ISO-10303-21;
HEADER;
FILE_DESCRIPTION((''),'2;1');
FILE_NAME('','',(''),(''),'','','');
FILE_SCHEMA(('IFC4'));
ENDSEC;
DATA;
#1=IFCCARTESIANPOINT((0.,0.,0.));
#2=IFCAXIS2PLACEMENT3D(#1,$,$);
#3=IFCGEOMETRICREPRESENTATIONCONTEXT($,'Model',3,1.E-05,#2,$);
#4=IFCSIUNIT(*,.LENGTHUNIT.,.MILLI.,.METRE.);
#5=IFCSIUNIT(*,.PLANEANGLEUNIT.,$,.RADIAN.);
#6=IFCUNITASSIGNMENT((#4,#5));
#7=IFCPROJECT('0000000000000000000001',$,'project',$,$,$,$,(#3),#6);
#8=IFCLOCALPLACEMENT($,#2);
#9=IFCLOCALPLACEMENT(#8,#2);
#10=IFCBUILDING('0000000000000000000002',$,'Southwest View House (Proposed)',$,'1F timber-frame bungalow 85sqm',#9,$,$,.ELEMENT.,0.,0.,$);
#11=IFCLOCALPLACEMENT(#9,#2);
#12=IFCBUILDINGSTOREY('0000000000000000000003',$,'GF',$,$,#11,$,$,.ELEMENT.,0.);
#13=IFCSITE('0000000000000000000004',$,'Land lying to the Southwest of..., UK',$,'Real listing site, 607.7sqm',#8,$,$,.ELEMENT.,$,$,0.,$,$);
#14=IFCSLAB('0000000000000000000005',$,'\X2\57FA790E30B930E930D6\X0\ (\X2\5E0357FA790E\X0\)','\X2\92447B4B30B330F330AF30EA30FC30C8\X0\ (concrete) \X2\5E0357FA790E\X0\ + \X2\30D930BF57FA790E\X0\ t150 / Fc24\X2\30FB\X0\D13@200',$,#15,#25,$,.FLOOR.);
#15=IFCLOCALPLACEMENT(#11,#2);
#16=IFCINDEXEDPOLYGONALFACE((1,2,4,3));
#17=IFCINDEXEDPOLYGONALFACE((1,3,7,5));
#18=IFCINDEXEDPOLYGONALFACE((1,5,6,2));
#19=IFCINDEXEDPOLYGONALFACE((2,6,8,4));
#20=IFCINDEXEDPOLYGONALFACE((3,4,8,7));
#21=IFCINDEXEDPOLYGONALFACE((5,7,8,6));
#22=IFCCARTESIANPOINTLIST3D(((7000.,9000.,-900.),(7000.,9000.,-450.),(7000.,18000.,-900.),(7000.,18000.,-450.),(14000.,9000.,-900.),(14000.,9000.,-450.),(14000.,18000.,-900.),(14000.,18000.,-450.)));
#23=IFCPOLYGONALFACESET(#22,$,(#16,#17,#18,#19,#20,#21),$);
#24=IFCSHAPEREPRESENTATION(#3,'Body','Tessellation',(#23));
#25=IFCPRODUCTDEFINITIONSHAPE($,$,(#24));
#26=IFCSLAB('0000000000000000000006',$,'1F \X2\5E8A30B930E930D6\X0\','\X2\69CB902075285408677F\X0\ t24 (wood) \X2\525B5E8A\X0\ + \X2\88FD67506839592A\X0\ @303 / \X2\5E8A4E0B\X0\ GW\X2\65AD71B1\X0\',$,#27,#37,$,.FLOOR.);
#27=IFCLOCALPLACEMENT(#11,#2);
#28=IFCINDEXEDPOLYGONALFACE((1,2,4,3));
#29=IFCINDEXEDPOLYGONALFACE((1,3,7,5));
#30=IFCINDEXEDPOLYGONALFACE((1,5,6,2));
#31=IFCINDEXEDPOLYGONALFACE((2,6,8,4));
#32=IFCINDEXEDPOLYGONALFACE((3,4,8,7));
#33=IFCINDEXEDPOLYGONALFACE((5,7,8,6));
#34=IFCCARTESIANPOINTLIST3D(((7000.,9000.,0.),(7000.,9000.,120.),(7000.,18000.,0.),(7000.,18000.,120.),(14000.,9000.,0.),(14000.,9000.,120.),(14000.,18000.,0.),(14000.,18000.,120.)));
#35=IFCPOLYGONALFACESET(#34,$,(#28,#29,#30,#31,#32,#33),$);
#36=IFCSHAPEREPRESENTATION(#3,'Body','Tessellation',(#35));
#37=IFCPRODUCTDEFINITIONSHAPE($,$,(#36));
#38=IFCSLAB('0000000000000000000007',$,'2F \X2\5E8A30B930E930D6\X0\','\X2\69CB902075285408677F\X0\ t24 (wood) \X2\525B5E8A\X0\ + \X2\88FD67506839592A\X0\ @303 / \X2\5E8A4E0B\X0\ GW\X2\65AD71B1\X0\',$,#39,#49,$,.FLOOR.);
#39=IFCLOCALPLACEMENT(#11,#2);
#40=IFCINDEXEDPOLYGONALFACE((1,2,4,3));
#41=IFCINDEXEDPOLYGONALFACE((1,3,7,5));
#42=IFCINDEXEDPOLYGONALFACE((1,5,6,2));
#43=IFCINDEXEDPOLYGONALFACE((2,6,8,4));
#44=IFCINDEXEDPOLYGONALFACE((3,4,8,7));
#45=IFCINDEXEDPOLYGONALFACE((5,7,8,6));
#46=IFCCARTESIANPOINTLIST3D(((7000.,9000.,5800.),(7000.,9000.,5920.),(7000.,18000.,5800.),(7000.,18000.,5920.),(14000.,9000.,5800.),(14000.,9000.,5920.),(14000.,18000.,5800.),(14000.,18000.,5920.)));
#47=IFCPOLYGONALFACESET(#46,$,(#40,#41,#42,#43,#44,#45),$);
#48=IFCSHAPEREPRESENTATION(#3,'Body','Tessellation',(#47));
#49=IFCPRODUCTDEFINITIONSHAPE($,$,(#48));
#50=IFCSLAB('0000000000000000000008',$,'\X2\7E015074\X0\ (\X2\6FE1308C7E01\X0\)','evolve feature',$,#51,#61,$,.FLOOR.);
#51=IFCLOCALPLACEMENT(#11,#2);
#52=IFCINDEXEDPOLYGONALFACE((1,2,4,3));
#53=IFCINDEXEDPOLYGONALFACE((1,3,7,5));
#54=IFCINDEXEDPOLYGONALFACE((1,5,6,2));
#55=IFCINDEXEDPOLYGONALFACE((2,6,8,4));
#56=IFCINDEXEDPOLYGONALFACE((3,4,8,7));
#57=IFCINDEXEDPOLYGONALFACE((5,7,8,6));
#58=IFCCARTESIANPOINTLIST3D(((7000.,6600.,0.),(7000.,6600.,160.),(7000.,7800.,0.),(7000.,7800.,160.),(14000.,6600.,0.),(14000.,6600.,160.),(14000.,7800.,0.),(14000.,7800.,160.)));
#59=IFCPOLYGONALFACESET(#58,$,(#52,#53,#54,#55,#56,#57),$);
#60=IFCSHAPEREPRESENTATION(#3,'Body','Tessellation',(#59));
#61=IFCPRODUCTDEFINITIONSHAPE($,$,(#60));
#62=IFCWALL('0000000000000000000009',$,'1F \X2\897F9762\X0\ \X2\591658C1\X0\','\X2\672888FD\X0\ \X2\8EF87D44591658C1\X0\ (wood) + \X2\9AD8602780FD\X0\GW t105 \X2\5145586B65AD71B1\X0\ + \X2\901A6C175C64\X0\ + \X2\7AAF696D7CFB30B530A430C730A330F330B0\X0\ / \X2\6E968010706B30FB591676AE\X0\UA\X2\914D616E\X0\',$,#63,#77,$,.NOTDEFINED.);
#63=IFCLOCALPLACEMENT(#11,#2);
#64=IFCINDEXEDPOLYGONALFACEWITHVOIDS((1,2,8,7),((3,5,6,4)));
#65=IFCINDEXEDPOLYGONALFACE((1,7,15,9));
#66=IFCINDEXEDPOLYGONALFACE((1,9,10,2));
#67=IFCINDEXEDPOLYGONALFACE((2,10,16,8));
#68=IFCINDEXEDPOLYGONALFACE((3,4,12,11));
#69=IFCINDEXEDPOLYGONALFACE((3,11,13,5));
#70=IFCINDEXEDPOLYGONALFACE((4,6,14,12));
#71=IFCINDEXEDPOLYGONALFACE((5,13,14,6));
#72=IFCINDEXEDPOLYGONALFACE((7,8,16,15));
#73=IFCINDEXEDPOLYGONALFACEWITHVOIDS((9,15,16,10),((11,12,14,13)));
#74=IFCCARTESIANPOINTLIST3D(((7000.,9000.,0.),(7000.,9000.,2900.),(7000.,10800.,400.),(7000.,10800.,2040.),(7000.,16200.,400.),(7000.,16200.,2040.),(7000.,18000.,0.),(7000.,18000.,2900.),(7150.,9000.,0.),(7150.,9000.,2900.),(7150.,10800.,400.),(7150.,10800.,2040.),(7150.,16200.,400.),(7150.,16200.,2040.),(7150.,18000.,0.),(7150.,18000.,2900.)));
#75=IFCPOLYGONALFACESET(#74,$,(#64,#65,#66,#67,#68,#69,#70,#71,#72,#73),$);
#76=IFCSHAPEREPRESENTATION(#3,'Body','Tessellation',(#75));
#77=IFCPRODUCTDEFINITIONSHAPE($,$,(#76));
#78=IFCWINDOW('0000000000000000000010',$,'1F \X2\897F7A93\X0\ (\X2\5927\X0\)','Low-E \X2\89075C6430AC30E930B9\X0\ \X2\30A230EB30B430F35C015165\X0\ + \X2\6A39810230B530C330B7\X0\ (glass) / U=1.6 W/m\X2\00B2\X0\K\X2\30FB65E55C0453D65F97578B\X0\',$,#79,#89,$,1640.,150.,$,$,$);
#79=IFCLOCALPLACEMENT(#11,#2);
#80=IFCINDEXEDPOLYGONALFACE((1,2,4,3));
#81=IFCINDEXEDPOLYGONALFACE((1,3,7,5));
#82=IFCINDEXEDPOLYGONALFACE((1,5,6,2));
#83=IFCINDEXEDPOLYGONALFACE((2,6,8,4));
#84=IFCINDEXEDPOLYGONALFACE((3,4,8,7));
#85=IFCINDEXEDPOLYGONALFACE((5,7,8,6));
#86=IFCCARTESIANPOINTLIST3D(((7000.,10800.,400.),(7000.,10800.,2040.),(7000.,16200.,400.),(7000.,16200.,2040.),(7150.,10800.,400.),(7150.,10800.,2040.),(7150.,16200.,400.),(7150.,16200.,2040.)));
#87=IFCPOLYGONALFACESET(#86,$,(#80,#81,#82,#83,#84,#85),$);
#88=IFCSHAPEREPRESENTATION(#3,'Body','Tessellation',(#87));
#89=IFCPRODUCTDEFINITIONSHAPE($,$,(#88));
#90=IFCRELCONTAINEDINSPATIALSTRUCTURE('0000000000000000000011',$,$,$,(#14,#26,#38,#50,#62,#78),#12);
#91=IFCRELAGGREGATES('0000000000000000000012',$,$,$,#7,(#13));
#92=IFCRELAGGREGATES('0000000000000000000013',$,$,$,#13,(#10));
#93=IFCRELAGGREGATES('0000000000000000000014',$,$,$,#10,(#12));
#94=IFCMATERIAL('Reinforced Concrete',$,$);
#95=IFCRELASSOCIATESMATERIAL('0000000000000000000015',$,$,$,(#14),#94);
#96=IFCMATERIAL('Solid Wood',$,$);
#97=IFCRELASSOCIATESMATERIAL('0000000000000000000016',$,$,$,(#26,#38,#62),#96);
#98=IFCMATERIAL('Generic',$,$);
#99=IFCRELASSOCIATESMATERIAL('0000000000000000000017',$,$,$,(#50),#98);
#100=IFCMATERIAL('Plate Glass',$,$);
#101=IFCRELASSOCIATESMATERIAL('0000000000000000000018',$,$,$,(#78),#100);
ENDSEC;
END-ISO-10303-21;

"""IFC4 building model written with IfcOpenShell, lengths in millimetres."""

from ifc_helpers import new_model, si_unit, frame, frame_2d, origin, place, context, project, spatial, rectangle, extrude, material, element, fill, save


model = new_model("IFC4")

# Units and contexts
model_context = context("Model", 3, precision=1e-05, world=origin())
ifc_project = project(units=[si_unit("LENGTHUNIT", "METRE", prefix="MILLI"), si_unit("PLANEANGLEUNIT", "RADIAN")], contexts=[model_context])

# Site, building, storey
site_placement = place(None, origin())
site = spatial("IfcSite", under=ifc_project, at=site_placement, Name="Land lying to the Southwest of..., UK", ObjectType="Real listing site, 607.7sqm", CompositionType="ELEMENT", RefElevation=0.0)
building_placement = place(site_placement, origin())
building = spatial("IfcBuilding", under=site, at=building_placement, Name="Southwest View House (Proposed)", ObjectType="1F timber-frame bungalow 85sqm", CompositionType="ELEMENT", ElevationOfRefHeight=0.0, ElevationOfTerrain=0.0)
storey_placement = place(building_placement, origin())
storey = spatial("IfcBuildingStorey", under=building, at=storey_placement, Name="GF", CompositionType="ELEMENT", Elevation=0.0)

# Slabs
ifc_material_1 = material(Name="Reinforced Concrete")
slab_1_placement = place(storey_placement, frame((3500.0, 4500.0, -450.0)))
element("IfcSlab", 1, at=slab_1_placement, inside=storey, material=ifc_material_1, Name="基礎スラブ (布基礎)", Description="鉄筋コンクリート (concrete) 布基礎 + ベタ基礎 t150 / Fc24・D13@200", PredefinedType="FLOOR", context=model_context, shape_type="SweptSolid", body=[
    extrude(rectangle(XDim=7000.0, YDim=9000.0, at=frame_2d((3500.0, 4500.0))), frame((3500.0, 4500.0, -450.0)), (0.0, 0.0, 1.0), 450.0),
])
ifc_material_2 = material(Name="Solid Wood")
slab_2_placement = place(storey_placement, frame((3500.0, 4500.0, 0.0)))
element("IfcSlab", 2, at=slab_2_placement, inside=storey, material=ifc_material_2, Name="1F 床スラブ", Description="構造用合板 t24 (wood) 剛床 + 製材根太 @303 / 床下 GW断熱", PredefinedType="FLOOR", context=model_context, shape_type="SweptSolid", body=[
    extrude(rectangle(XDim=7000.0, YDim=9000.0, at=frame_2d((3500.0, 4500.0))), frame((3500.0, 4500.0, 0.0)), (0.0, 0.0, 1.0), 120.0),
])
slab_3_placement = place(storey_placement, frame((3500.0, 4500.0, 2900.0)))
element("IfcSlab", 3, at=slab_3_placement, inside=storey, material=ifc_material_2, Name="2F 床スラブ", Description="構造用合板 t24 (wood) 剛床 + 製材根太 @303 / 床下 GW断熱", PredefinedType="FLOOR", context=model_context, shape_type="SweptSolid", body=[
    extrude(rectangle(XDim=7000.0, YDim=9000.0, at=frame_2d((3500.0, 4500.0))), frame((3500.0, 4500.0, 2900.0)), (0.0, 0.0, 1.0), 120.0),
])
ifc_material_3 = material(Name="Generic")
slab_4_placement = place(storey_placement, frame((3500.0, 3300.0, 0.0)))
element("IfcSlab", 4, at=slab_4_placement, inside=storey, material=ifc_material_3, Name="縁側 (濡れ縁)", Description="evolve feature", PredefinedType="FLOOR", context=model_context, shape_type="SweptSolid", body=[
    extrude(rectangle(XDim=7000.0, YDim=1200.0, at=frame_2d((3500.0, 600.0))), frame((3500.0, 3300.0, 0.0)), (0.0, 0.0, 1.0), 160.0),
])

# Shared definitions
ifc_material_4 = material(Name="Plate Glass")

# Wall, opening, window
wall_1_placement = place(storey_placement, frame((3500.0, 4500.0, 0.0)))
wall_1 = element("IfcWall", 5, at=wall_1_placement, inside=storey, material=ifc_material_2, Name="1F 西面 外壁", Description="木製 軸組外壁 (wood) + 高性能GW t105 充填断熱 + 通気層 + 窯業系サイディング / 準耐火・外皮UA配慮", PredefinedType="NOTDEFINED", context=model_context, shape_type="SweptSolid", body=[
    extrude(rectangle(XDim=150.0, YDim=9000.0, at=frame_2d((75.0, 4500.0))), frame((3500.0, 4500.0, 0.0)), (0.0, 0.0, 1.0), 2900.0),
])
opening_1_placement = place(storey_placement, frame((3500.0, 5400.0, 200.0)))
opening_1 = element("IfcOpeningElement", 6, at=opening_1_placement, cuts=wall_1, PredefinedType="NOTDEFINED", context=model_context, shape_type="SweptSolid", body=[
    extrude(rectangle(XDim=150.0, YDim=5400.0, at=frame_2d((75.0, 2700.0))), frame((3500.0, 5400.0, 200.0)), (0.0, 0.0, 1.0), 1640.0),
])
window_1_placement = place(storey_placement, frame((3500.0, 5400.0, 200.0)))
window_1 = element("IfcWindow", 7, at=window_1_placement, inside=storey, material=ifc_material_4, Name="1F 西窓 (大)", Description="Low-E 複層ガラス アルゴン封入 + 樹脂サッシ (glass) / U=1.6 W/m²K・日射取得型", OverallHeight=1640.0, OverallWidth=150.0, context=model_context, shape_type="SweptSolid", body=[
    extrude(rectangle(XDim=150.0, YDim=5400.0, at=frame_2d((75.0, 2700.0))), frame((3500.0, 5400.0, 200.0)), (0.0, 0.0, 1.0), 1640.0),
])
fill(opening_1, window_1)

save(model, "model.ifc")
